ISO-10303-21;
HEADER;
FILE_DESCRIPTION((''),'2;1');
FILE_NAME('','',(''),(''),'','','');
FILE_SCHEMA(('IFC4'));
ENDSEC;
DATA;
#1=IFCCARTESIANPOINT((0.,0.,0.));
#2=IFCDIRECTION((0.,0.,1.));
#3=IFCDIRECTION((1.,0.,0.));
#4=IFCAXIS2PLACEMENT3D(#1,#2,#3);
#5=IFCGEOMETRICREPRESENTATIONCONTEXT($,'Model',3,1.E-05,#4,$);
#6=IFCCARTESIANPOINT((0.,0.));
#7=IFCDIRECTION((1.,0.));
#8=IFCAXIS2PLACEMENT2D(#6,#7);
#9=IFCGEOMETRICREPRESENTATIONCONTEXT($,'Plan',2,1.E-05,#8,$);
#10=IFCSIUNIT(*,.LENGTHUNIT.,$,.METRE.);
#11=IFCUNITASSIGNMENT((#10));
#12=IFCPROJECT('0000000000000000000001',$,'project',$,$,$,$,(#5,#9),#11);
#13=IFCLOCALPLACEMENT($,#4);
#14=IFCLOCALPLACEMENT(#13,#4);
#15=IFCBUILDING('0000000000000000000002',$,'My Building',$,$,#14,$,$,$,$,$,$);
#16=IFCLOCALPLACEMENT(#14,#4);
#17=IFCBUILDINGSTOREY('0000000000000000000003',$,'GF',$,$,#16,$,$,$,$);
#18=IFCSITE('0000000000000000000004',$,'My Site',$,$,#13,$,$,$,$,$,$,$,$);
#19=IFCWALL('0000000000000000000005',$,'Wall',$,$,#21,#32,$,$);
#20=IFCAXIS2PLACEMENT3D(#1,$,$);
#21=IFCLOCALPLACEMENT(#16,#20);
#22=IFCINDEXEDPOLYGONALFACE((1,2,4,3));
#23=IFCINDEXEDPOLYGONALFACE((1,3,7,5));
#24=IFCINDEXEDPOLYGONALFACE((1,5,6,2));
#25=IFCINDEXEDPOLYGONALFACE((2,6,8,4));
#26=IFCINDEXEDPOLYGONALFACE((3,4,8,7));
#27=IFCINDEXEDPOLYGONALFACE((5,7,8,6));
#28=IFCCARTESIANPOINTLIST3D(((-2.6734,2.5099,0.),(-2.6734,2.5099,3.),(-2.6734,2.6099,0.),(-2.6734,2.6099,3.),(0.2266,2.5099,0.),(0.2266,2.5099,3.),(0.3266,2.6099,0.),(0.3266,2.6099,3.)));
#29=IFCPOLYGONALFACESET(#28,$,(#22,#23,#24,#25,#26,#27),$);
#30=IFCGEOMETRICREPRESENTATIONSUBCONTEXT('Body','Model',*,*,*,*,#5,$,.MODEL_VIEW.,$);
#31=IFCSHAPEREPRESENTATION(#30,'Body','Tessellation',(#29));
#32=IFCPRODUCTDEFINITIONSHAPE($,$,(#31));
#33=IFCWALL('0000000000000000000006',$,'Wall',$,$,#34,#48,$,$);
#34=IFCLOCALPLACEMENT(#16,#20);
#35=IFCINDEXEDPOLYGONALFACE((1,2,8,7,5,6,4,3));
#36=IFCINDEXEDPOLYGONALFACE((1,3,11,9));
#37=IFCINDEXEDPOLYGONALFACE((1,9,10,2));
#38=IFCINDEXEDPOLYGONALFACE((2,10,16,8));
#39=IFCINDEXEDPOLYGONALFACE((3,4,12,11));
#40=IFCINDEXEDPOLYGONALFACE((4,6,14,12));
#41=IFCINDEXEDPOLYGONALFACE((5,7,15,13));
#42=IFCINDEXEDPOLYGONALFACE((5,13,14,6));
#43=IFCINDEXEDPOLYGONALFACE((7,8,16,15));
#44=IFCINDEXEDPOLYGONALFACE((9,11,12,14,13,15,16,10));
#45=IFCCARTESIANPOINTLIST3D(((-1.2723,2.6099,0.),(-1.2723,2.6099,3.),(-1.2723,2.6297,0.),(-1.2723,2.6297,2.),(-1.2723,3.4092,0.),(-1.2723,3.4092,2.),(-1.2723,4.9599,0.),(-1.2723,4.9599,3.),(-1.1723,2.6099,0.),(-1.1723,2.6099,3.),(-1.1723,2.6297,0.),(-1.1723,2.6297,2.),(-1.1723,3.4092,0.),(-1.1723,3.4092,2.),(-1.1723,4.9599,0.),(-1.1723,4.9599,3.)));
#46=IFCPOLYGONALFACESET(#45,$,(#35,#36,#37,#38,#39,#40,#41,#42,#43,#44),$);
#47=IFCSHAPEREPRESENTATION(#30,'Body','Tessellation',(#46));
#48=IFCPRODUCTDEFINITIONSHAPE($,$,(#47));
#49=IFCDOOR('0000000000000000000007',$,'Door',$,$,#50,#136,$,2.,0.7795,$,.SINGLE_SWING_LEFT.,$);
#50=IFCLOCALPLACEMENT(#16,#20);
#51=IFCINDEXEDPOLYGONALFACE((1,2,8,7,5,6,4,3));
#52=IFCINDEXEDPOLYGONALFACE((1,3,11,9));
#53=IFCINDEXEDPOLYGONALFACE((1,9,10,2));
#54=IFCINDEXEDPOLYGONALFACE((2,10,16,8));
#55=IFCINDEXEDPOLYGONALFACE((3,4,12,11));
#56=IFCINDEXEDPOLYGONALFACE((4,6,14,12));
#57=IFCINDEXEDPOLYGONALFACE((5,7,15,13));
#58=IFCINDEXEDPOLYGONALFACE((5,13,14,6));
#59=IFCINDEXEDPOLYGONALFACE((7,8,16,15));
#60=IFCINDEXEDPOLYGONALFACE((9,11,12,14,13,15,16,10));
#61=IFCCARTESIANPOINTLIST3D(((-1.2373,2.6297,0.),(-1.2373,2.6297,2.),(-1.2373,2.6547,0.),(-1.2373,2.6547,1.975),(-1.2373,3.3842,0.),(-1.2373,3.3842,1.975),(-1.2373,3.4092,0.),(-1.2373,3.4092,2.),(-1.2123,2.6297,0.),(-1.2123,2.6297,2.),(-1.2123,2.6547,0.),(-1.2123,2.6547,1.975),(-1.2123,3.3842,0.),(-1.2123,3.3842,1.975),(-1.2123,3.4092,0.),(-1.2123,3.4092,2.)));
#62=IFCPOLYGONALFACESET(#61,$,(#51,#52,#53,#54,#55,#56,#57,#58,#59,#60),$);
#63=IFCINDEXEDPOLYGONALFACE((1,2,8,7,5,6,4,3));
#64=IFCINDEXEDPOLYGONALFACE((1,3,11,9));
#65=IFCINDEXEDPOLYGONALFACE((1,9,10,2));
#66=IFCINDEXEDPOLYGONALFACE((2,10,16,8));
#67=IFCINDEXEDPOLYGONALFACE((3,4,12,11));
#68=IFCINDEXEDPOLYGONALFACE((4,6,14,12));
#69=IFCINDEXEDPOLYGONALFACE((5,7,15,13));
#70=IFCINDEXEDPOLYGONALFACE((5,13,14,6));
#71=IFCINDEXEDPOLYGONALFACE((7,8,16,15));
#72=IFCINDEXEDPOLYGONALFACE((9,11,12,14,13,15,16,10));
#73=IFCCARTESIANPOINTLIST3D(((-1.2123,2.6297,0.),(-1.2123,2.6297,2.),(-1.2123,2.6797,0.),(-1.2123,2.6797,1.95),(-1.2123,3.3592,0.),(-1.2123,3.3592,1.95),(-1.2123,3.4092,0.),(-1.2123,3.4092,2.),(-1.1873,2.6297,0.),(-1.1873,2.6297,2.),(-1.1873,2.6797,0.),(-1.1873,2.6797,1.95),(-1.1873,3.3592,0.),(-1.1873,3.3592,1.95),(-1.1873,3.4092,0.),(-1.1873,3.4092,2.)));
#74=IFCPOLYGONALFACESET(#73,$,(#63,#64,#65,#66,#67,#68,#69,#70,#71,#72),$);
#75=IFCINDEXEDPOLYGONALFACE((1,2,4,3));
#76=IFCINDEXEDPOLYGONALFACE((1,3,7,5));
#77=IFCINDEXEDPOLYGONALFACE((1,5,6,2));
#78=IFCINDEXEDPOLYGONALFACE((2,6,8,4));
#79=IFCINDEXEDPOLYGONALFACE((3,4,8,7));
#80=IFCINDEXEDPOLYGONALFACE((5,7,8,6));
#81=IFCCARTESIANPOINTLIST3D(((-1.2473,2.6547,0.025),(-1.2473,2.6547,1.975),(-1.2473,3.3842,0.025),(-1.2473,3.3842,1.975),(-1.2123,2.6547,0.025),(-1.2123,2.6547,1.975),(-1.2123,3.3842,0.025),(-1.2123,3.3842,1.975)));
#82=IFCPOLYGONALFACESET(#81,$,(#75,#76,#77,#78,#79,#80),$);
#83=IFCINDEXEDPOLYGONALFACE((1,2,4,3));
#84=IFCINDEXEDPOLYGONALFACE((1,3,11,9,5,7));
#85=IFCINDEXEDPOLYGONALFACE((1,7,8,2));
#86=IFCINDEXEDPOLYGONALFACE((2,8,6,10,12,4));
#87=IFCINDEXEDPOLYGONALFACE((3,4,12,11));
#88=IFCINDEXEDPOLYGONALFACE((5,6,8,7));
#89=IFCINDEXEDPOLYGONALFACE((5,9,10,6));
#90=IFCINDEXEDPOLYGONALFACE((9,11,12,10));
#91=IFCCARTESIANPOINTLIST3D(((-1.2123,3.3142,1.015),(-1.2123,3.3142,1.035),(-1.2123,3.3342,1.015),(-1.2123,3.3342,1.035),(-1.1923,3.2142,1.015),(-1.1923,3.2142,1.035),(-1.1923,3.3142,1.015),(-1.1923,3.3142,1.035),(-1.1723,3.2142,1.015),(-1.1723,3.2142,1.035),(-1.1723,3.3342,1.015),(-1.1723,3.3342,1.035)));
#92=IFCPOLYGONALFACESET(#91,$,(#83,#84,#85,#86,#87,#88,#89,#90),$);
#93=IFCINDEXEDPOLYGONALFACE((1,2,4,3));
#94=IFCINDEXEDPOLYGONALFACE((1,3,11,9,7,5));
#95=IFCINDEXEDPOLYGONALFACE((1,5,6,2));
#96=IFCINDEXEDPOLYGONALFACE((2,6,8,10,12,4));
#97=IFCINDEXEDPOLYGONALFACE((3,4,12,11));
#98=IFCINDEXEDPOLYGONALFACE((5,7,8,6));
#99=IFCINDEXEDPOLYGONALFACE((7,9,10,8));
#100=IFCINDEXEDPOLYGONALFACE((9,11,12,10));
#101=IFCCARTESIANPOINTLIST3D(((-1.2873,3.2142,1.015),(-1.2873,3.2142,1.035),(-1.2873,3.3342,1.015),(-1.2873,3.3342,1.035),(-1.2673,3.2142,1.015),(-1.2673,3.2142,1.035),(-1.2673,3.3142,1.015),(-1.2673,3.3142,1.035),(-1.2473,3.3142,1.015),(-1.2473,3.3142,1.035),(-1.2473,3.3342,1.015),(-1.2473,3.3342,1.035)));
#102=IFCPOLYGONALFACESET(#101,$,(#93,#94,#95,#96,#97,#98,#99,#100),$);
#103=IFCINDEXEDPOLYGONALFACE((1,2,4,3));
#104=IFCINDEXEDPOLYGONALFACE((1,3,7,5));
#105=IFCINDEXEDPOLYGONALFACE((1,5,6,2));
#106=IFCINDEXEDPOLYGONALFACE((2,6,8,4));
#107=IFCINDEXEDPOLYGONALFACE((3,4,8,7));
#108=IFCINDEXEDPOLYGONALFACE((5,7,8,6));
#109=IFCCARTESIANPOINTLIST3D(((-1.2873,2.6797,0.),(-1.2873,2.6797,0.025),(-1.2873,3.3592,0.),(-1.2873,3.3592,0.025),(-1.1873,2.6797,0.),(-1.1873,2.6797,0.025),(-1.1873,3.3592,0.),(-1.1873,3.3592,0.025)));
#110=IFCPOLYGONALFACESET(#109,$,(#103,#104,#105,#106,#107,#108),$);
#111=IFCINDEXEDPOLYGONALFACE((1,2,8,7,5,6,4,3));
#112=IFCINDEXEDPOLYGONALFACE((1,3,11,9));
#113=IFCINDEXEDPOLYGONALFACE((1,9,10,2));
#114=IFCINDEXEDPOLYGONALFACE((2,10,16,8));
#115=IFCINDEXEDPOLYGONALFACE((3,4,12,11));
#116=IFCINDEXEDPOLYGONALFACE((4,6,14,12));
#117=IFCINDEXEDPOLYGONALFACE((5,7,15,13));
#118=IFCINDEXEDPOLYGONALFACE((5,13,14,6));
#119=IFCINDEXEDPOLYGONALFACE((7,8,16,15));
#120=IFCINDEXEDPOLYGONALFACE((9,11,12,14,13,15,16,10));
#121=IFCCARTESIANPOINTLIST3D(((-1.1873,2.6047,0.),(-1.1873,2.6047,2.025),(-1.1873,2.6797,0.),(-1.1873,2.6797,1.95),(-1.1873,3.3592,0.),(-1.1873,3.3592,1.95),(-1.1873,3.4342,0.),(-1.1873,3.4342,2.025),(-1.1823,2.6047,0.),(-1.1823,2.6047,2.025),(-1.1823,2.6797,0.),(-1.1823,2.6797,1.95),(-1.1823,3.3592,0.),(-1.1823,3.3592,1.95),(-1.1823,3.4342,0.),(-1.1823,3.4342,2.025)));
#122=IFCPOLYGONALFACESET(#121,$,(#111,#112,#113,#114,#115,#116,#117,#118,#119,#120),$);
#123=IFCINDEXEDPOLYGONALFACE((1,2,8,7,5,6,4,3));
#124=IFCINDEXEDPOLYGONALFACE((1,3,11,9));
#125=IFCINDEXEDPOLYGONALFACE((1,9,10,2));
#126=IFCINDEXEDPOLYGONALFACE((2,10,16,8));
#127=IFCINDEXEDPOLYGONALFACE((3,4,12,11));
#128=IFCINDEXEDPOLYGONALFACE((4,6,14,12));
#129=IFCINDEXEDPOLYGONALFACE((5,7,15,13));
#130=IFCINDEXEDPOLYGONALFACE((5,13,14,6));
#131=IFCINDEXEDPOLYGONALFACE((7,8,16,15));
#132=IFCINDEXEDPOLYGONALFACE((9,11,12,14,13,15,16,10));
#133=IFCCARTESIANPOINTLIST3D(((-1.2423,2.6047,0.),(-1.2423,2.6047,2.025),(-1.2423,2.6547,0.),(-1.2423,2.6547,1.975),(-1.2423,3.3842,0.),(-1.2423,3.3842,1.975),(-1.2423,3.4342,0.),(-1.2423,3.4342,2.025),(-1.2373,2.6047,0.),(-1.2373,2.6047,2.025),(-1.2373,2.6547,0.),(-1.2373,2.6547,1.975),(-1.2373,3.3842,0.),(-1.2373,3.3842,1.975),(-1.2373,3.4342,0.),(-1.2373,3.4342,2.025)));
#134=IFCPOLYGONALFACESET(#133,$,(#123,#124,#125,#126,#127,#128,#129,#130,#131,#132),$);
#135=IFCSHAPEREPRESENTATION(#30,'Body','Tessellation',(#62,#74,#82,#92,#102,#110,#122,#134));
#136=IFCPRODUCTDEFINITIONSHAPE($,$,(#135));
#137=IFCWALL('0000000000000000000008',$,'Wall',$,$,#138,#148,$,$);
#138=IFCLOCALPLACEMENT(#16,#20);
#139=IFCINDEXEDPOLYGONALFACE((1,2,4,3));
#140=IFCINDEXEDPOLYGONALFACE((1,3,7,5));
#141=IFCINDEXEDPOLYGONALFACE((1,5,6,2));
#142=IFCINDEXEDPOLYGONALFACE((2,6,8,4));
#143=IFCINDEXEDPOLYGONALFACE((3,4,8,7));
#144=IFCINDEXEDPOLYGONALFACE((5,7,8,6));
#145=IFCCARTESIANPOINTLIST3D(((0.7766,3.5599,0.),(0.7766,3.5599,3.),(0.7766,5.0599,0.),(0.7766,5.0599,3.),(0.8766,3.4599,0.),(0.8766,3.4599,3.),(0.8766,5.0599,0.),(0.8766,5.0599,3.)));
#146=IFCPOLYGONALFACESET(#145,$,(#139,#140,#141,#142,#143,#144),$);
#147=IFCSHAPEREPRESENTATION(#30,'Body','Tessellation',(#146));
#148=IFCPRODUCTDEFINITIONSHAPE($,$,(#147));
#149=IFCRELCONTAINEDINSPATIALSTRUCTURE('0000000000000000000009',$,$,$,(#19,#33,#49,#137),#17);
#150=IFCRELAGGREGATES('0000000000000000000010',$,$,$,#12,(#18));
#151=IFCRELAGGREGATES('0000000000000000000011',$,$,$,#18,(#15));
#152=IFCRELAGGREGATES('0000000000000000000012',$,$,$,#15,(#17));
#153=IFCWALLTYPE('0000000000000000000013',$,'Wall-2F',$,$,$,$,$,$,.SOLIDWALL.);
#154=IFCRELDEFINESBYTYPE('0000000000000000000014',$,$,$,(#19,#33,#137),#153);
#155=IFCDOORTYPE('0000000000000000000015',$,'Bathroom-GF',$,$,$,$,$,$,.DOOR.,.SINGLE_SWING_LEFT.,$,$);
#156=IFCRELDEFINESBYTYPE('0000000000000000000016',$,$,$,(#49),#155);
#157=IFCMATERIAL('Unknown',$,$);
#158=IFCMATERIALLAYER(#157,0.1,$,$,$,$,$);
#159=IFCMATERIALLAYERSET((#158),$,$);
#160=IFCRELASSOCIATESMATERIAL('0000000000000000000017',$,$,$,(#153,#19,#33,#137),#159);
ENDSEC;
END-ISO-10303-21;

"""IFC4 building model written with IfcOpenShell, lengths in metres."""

from ifc_helpers import new_model, entity, si_unit, frame, origin_with_axes, origin_2d_with_axis, place, context, subcontext, project, spatial, line, indexed_curve, outline, extrude, shape, source, transform, mapped, material, layer, layer_set, layer_usage, type_object, type_shapes, element, fill, save


model = new_model("IFC4")

# Units and contexts
model_context = context("Model", 3, precision=1e-05, world=origin_with_axes())
plan_context = context("Plan", 2, precision=1e-05, world=origin_2d_with_axis())
body_context_1 = subcontext(model_context, "Body", "Model", "MODEL_VIEW")
body_context_2 = subcontext(plan_context, "Body", "Plan", "PLAN_VIEW")
ifc_project = project(units=[si_unit("LENGTHUNIT", "METRE")], contexts=[model_context, plan_context])

# Site, building, storey
site_placement = place(None, origin_with_axes())
site = spatial("IfcSite", under=ifc_project, at=site_placement, Name="My Site")
building_placement = place(site_placement, origin_with_axes())
building = spatial("IfcBuilding", under=site, at=building_placement, Name="My Building")
storey_placement = place(building_placement, origin_with_axes())
storey = spatial("IfcBuildingStorey", under=building, at=storey_placement, Name="GF")

# Shared definitions
ifc_material_1 = material(Name="Unknown")

# Shared definitions
ifc_layer_1 = layer(ifc_material_1, 0.1)
ifc_layer_set_1 = layer_set([ifc_layer_1])
wall_type = type_object("IfcWallType", Name="Wall-2F", PredefinedType="SOLIDWALL", material=ifc_layer_set_1)

# Wall
ifc_layer_usage_1 = layer_usage(ifc_layer_set_1, "AXIS2", "POSITIVE", 0.0)
wall_1_placement = place(storey_placement, frame((0.3266, 2.6099, 0.0), z_axis=(0.0, 0.0, 1.0), x_axis=(-1.0, 0.0, 0.0)))
element("IfcWall", 1, at=wall_1_placement, inside=storey, type_object=wall_type, material=ifc_layer_usage_1, Name="Wall", context=body_context_1, shape_type="SweptSolid", body=[
    extrude(outline(indexed_curve([(0.0, 0.0), (0.1, 0.1), (3.0, 0.1), (3.0, 0.0)], segments=[line(1, 2, 3, 4, 1)])), origin_with_axes(), (0.0, 0.0, 1.0), 3.0),
])

# Wall, opening, door
ifc_layer_usage_2 = layer_usage(ifc_layer_set_1, "AXIS2", "POSITIVE", 0.0)
wall_2_placement = place(storey_placement, frame((-1.1723, 2.6099, 0.0), z_axis=(0.0, 0.0, 1.0), x_axis=(0.0, 1.0, 0.0)))
wall_2 = element("IfcWall", 2, at=wall_2_placement, inside=storey, type_object=wall_type, material=ifc_layer_usage_2, Name="Wall", context=body_context_1, shape_type="SweptSolid", body=[
    extrude(outline(indexed_curve([(0.0, 0.0), (0.0, 0.1), (2.35, 0.1), (2.35, 0.0)], segments=[line(1, 2, 3, 4, 1)])), origin_with_axes(), (0.0, 0.0, 1.0), 3.0),
])
shared_shape_1 = source(origin_with_axes(), body_context_1, "Body", "SweptSolid", [
    extrude(outline(indexed_curve([(0.0, 0.0), (0.7795, 0.0), (0.7795, 2.0), (0.0, 2.0)], segments=[line(1, 2, 3, 4, 1)])), frame((0.0, -0.6, 0.0), z_axis=(0.0, -1.0, 0.0), x_axis=(1.0, 0.0, 0.0)), (0.0, 0.0, -1.0), 1.2),
])
opening_1_placement = place(wall_2_placement, frame((0.0198, 0.015, 0.0), z_axis=(0.0, 0.0, 1.0), x_axis=(1.0, 0.0, 0.0)))
opening_1 = element("IfcOpeningElement", 3, at=opening_1_placement, cuts=wall_2, PredefinedType="OPENING", context=body_context_1, shape_type="MappedRepresentation", body=[
    mapped(shared_shape_1, transform((0.0, 0.0, 0.0), x_axis=(1.0, 0.0, 0.0), y_axis=(0.0, 1.0, 0.0), z_axis=(0.0, 0.0, 1.0), scale=1.0)),
])
door_type_1 = type_object("IfcDoorType", Name="Bathroom-GF", OperationType="SINGLE_SWING_LEFT", PredefinedType="DOOR")
shared_shape_2 = source(origin_with_axes(), body_context_1, "Body", "SweptSolid", [
    extrude(outline(indexed_curve([(0.0, 0.0), (0.0, 2.0), (0.7795, 2.0), (0.7795, 0.0), (0.7545, 0.0), (0.7545, 1.975), (0.025, 1.975), (0.025, 0.0)], segments=[line(1, 2, 3, 4, 5, 6, 7, 8, 1)])), frame((0.0, 0.025, 0.0), z_axis=(0.0, -1.0, 0.0), x_axis=(1.0, 0.0, 0.0)), (0.0, 0.0, -1.0), 0.025),
    extrude(outline(indexed_curve([(0.0, 0.0), (0.0, 2.0), (0.7795, 2.0), (0.7795, 0.0), (0.7295, 0.0), (0.7295, 1.95), (0.05, 1.95), (0.05, 0.0)], segments=[line(1, 2, 3, 4, 5, 6, 7, 8, 1)])), frame((0.0, 0.0, 0.0), z_axis=(0.0, -1.0, 0.0), x_axis=(1.0, 0.0, 0.0)), (0.0, 0.0, -1.0), 0.025),
    extrude(outline(indexed_curve([(0.0, 0.0), (0.7295, 0.0), (0.7295, 0.035), (0.0, 0.035)], segments=[line(1, 2, 3, 4, 1)])), frame((0.025, 0.025, 0.025), z_axis=(0.0, 0.0, 1.0), x_axis=(1.0, 0.0, 0.0)), (0.0, 0.0, 1.0), 1.95),
    extrude(outline(indexed_curve([(0.0, 0.0), (0.0, -0.04), (-0.12, -0.04), (-0.12, -0.02), (-0.02, -0.02), (-0.02, 0.0)], segments=[line(1, 2, 3, 4, 5, 6, 1)])), frame((0.7045, 0.025, 1.015), z_axis=(0.0, 0.0, 1.0), x_axis=(1.0, 0.0, 0.0)), (0.0, 0.0, 1.0), 0.02),
    extrude(outline(indexed_curve([(0.0, 0.0), (0.0, 0.04), (-0.12, 0.04), (-0.12, 0.02), (-0.02, 0.02), (-0.02, 0.0)], segments=[line(1, 2, 3, 4, 5, 6, 1)])), frame((0.7045, 0.06, 1.015), z_axis=(0.0, 0.0, 1.0), x_axis=(1.0, 0.0, 0.0)), (0.0, 0.0, 1.0), 0.02),
    extrude(outline(indexed_curve([(0.0, 0.0), (0.6795, 0.0), (0.6795, 0.1), (0.0, 0.1)], segments=[line(1, 2, 3, 4, 1)])), frame((0.05, 0.0, 0.0), z_axis=(0.0, 0.0, 1.0), x_axis=(1.0, 0.0, 0.0)), (0.0, 0.0, 1.0), 0.025),
    extrude(outline(indexed_curve([(0.0, 0.0), (0.0, 2.025), (0.8295, 2.025), (0.8295, 0.0), (0.7545, 0.0), (0.7545, 1.95), (0.075, 1.95), (0.075, 0.0)], segments=[line(1, 2, 3, 4, 5, 6, 7, 8, 1)])), frame((-0.025, -0.005, 0.0), z_axis=(0.0, -1.0, 0.0), x_axis=(1.0, 0.0, 0.0)), (0.0, 0.0, -1.0), 0.005),
    extrude(outline(indexed_curve([(0.0, 0.0), (0.0, 2.025), (0.8295, 2.025), (0.8295, 0.0), (0.7795, 0.0), (0.7795, 1.975), (0.05, 1.975), (0.05, 0.0)], segments=[line(1, 2, 3, 4, 5, 6, 7, 8, 1)])), frame((-0.025, 0.05, 0.0), z_axis=(0.0, -1.0, 0.0), x_axis=(1.0, 0.0, 0.0)), (0.0, 0.0, -1.0), 0.005),
])
shared_shape_3 = source(origin_with_axes(), body_context_2, "Body", "Curve2D", [
    entity("IfcIndexedPolyCurve", entity("IfcCartesianPointList2D", [[0.0, 0.0], [0.0, 0.05], [0.025, 0.05], [0.025, 0.025], [0.05, 0.025], [0.05, 0.0]]), [entity("IfcLineIndex", [1, 2, 3, 4, 5, 6, 1])]),
    entity("IfcIndexedPolyCurve", entity("IfcCartesianPointList2D", [[0.7795, 0.0], [0.7795, 0.05], [0.7545, 0.05], [0.7545, 0.025], [0.7295, 0.025], [0.7295, 0.0]]), [entity("IfcLineIndex", [1, 2, 3, 4, 5, 6, 1])]),
    entity("IfcTrimmedCurve", entity("IfcEllipse", entity("IfcAxis2Placement2D", entity("IfcCartesianPoint", [0.06, 0.05]), entity("IfcDirection", [1.0, 0.0])), 0.6945, 0.7295), [entity("IfcCartesianPoint", [0.7545, 0.05])], [entity("IfcCartesianPoint", [0.06, 0.7795])], True, "CARTESIAN"),
    entity("IfcIndexedPolyCurve", entity("IfcCartesianPointList2D", [[0.025, 0.05], [0.06, 0.05], [0.06, 0.7795], [0.025, 0.7795]]), [entity("IfcLineIndex", [1, 2, 3, 4, 1])]),
])
type_shapes(door_type_1, [shared_shape_2, shared_shape_3])
door_1_placement = place(opening_1_placement, frame((0.0, 0.0, 0.0), z_axis=(0.0, 0.0, 1.0), x_axis=(1.0, 0.0, 0.0)))
door_1 = element("IfcDoor", 4, at=door_1_placement, inside=storey, type_object=door_type_1, Name="Door", OperationType="SINGLE_SWING_LEFT", OverallHeight=2.0, OverallWidth=0.7795, shapes=[
    shape(body_context_1, "Body", "MappedRepresentation", [mapped(shared_shape_2, transform((0.0, 0.0, 0.0), x_axis=(1.0, 0.0, 0.0), y_axis=(0.0, 1.0, 0.0), z_axis=(0.0, 0.0, 1.0), scale=1.0))]),
    shape(body_context_2, "Body", "MappedRepresentation", [mapped(shared_shape_3, transform((0.0, 0.0, 0.0), x_axis=(1.0, 0.0, 0.0), y_axis=(0.0, 1.0, 0.0), z_axis=(0.0, 0.0, 1.0), scale=1.0))]),
])
fill(opening_1, door_1)

# Wall
ifc_layer_usage_3 = layer_usage(ifc_layer_set_1, "AXIS2", "POSITIVE", 0.0)
wall_3_placement = place(storey_placement, frame((0.7766, 5.0599, 0.0), z_axis=(0.0, 0.0, 1.0), x_axis=(0.0, -1.0, 0.0)))
element("IfcWall", 5, at=wall_3_placement, inside=storey, type_object=wall_type, material=ifc_layer_usage_3, Name="Wall", context=body_context_1, shape_type="SweptSolid", body=[
    extrude(outline(indexed_curve([(0.0, 0.0), (0.0, 0.1), (1.6, 0.1), (1.5, 0.0)], segments=[line(1, 2, 3, 4, 1)])), origin_with_axes(), (0.0, 0.0, 1.0), 3.0),
])

save(model, "model.ifc")
